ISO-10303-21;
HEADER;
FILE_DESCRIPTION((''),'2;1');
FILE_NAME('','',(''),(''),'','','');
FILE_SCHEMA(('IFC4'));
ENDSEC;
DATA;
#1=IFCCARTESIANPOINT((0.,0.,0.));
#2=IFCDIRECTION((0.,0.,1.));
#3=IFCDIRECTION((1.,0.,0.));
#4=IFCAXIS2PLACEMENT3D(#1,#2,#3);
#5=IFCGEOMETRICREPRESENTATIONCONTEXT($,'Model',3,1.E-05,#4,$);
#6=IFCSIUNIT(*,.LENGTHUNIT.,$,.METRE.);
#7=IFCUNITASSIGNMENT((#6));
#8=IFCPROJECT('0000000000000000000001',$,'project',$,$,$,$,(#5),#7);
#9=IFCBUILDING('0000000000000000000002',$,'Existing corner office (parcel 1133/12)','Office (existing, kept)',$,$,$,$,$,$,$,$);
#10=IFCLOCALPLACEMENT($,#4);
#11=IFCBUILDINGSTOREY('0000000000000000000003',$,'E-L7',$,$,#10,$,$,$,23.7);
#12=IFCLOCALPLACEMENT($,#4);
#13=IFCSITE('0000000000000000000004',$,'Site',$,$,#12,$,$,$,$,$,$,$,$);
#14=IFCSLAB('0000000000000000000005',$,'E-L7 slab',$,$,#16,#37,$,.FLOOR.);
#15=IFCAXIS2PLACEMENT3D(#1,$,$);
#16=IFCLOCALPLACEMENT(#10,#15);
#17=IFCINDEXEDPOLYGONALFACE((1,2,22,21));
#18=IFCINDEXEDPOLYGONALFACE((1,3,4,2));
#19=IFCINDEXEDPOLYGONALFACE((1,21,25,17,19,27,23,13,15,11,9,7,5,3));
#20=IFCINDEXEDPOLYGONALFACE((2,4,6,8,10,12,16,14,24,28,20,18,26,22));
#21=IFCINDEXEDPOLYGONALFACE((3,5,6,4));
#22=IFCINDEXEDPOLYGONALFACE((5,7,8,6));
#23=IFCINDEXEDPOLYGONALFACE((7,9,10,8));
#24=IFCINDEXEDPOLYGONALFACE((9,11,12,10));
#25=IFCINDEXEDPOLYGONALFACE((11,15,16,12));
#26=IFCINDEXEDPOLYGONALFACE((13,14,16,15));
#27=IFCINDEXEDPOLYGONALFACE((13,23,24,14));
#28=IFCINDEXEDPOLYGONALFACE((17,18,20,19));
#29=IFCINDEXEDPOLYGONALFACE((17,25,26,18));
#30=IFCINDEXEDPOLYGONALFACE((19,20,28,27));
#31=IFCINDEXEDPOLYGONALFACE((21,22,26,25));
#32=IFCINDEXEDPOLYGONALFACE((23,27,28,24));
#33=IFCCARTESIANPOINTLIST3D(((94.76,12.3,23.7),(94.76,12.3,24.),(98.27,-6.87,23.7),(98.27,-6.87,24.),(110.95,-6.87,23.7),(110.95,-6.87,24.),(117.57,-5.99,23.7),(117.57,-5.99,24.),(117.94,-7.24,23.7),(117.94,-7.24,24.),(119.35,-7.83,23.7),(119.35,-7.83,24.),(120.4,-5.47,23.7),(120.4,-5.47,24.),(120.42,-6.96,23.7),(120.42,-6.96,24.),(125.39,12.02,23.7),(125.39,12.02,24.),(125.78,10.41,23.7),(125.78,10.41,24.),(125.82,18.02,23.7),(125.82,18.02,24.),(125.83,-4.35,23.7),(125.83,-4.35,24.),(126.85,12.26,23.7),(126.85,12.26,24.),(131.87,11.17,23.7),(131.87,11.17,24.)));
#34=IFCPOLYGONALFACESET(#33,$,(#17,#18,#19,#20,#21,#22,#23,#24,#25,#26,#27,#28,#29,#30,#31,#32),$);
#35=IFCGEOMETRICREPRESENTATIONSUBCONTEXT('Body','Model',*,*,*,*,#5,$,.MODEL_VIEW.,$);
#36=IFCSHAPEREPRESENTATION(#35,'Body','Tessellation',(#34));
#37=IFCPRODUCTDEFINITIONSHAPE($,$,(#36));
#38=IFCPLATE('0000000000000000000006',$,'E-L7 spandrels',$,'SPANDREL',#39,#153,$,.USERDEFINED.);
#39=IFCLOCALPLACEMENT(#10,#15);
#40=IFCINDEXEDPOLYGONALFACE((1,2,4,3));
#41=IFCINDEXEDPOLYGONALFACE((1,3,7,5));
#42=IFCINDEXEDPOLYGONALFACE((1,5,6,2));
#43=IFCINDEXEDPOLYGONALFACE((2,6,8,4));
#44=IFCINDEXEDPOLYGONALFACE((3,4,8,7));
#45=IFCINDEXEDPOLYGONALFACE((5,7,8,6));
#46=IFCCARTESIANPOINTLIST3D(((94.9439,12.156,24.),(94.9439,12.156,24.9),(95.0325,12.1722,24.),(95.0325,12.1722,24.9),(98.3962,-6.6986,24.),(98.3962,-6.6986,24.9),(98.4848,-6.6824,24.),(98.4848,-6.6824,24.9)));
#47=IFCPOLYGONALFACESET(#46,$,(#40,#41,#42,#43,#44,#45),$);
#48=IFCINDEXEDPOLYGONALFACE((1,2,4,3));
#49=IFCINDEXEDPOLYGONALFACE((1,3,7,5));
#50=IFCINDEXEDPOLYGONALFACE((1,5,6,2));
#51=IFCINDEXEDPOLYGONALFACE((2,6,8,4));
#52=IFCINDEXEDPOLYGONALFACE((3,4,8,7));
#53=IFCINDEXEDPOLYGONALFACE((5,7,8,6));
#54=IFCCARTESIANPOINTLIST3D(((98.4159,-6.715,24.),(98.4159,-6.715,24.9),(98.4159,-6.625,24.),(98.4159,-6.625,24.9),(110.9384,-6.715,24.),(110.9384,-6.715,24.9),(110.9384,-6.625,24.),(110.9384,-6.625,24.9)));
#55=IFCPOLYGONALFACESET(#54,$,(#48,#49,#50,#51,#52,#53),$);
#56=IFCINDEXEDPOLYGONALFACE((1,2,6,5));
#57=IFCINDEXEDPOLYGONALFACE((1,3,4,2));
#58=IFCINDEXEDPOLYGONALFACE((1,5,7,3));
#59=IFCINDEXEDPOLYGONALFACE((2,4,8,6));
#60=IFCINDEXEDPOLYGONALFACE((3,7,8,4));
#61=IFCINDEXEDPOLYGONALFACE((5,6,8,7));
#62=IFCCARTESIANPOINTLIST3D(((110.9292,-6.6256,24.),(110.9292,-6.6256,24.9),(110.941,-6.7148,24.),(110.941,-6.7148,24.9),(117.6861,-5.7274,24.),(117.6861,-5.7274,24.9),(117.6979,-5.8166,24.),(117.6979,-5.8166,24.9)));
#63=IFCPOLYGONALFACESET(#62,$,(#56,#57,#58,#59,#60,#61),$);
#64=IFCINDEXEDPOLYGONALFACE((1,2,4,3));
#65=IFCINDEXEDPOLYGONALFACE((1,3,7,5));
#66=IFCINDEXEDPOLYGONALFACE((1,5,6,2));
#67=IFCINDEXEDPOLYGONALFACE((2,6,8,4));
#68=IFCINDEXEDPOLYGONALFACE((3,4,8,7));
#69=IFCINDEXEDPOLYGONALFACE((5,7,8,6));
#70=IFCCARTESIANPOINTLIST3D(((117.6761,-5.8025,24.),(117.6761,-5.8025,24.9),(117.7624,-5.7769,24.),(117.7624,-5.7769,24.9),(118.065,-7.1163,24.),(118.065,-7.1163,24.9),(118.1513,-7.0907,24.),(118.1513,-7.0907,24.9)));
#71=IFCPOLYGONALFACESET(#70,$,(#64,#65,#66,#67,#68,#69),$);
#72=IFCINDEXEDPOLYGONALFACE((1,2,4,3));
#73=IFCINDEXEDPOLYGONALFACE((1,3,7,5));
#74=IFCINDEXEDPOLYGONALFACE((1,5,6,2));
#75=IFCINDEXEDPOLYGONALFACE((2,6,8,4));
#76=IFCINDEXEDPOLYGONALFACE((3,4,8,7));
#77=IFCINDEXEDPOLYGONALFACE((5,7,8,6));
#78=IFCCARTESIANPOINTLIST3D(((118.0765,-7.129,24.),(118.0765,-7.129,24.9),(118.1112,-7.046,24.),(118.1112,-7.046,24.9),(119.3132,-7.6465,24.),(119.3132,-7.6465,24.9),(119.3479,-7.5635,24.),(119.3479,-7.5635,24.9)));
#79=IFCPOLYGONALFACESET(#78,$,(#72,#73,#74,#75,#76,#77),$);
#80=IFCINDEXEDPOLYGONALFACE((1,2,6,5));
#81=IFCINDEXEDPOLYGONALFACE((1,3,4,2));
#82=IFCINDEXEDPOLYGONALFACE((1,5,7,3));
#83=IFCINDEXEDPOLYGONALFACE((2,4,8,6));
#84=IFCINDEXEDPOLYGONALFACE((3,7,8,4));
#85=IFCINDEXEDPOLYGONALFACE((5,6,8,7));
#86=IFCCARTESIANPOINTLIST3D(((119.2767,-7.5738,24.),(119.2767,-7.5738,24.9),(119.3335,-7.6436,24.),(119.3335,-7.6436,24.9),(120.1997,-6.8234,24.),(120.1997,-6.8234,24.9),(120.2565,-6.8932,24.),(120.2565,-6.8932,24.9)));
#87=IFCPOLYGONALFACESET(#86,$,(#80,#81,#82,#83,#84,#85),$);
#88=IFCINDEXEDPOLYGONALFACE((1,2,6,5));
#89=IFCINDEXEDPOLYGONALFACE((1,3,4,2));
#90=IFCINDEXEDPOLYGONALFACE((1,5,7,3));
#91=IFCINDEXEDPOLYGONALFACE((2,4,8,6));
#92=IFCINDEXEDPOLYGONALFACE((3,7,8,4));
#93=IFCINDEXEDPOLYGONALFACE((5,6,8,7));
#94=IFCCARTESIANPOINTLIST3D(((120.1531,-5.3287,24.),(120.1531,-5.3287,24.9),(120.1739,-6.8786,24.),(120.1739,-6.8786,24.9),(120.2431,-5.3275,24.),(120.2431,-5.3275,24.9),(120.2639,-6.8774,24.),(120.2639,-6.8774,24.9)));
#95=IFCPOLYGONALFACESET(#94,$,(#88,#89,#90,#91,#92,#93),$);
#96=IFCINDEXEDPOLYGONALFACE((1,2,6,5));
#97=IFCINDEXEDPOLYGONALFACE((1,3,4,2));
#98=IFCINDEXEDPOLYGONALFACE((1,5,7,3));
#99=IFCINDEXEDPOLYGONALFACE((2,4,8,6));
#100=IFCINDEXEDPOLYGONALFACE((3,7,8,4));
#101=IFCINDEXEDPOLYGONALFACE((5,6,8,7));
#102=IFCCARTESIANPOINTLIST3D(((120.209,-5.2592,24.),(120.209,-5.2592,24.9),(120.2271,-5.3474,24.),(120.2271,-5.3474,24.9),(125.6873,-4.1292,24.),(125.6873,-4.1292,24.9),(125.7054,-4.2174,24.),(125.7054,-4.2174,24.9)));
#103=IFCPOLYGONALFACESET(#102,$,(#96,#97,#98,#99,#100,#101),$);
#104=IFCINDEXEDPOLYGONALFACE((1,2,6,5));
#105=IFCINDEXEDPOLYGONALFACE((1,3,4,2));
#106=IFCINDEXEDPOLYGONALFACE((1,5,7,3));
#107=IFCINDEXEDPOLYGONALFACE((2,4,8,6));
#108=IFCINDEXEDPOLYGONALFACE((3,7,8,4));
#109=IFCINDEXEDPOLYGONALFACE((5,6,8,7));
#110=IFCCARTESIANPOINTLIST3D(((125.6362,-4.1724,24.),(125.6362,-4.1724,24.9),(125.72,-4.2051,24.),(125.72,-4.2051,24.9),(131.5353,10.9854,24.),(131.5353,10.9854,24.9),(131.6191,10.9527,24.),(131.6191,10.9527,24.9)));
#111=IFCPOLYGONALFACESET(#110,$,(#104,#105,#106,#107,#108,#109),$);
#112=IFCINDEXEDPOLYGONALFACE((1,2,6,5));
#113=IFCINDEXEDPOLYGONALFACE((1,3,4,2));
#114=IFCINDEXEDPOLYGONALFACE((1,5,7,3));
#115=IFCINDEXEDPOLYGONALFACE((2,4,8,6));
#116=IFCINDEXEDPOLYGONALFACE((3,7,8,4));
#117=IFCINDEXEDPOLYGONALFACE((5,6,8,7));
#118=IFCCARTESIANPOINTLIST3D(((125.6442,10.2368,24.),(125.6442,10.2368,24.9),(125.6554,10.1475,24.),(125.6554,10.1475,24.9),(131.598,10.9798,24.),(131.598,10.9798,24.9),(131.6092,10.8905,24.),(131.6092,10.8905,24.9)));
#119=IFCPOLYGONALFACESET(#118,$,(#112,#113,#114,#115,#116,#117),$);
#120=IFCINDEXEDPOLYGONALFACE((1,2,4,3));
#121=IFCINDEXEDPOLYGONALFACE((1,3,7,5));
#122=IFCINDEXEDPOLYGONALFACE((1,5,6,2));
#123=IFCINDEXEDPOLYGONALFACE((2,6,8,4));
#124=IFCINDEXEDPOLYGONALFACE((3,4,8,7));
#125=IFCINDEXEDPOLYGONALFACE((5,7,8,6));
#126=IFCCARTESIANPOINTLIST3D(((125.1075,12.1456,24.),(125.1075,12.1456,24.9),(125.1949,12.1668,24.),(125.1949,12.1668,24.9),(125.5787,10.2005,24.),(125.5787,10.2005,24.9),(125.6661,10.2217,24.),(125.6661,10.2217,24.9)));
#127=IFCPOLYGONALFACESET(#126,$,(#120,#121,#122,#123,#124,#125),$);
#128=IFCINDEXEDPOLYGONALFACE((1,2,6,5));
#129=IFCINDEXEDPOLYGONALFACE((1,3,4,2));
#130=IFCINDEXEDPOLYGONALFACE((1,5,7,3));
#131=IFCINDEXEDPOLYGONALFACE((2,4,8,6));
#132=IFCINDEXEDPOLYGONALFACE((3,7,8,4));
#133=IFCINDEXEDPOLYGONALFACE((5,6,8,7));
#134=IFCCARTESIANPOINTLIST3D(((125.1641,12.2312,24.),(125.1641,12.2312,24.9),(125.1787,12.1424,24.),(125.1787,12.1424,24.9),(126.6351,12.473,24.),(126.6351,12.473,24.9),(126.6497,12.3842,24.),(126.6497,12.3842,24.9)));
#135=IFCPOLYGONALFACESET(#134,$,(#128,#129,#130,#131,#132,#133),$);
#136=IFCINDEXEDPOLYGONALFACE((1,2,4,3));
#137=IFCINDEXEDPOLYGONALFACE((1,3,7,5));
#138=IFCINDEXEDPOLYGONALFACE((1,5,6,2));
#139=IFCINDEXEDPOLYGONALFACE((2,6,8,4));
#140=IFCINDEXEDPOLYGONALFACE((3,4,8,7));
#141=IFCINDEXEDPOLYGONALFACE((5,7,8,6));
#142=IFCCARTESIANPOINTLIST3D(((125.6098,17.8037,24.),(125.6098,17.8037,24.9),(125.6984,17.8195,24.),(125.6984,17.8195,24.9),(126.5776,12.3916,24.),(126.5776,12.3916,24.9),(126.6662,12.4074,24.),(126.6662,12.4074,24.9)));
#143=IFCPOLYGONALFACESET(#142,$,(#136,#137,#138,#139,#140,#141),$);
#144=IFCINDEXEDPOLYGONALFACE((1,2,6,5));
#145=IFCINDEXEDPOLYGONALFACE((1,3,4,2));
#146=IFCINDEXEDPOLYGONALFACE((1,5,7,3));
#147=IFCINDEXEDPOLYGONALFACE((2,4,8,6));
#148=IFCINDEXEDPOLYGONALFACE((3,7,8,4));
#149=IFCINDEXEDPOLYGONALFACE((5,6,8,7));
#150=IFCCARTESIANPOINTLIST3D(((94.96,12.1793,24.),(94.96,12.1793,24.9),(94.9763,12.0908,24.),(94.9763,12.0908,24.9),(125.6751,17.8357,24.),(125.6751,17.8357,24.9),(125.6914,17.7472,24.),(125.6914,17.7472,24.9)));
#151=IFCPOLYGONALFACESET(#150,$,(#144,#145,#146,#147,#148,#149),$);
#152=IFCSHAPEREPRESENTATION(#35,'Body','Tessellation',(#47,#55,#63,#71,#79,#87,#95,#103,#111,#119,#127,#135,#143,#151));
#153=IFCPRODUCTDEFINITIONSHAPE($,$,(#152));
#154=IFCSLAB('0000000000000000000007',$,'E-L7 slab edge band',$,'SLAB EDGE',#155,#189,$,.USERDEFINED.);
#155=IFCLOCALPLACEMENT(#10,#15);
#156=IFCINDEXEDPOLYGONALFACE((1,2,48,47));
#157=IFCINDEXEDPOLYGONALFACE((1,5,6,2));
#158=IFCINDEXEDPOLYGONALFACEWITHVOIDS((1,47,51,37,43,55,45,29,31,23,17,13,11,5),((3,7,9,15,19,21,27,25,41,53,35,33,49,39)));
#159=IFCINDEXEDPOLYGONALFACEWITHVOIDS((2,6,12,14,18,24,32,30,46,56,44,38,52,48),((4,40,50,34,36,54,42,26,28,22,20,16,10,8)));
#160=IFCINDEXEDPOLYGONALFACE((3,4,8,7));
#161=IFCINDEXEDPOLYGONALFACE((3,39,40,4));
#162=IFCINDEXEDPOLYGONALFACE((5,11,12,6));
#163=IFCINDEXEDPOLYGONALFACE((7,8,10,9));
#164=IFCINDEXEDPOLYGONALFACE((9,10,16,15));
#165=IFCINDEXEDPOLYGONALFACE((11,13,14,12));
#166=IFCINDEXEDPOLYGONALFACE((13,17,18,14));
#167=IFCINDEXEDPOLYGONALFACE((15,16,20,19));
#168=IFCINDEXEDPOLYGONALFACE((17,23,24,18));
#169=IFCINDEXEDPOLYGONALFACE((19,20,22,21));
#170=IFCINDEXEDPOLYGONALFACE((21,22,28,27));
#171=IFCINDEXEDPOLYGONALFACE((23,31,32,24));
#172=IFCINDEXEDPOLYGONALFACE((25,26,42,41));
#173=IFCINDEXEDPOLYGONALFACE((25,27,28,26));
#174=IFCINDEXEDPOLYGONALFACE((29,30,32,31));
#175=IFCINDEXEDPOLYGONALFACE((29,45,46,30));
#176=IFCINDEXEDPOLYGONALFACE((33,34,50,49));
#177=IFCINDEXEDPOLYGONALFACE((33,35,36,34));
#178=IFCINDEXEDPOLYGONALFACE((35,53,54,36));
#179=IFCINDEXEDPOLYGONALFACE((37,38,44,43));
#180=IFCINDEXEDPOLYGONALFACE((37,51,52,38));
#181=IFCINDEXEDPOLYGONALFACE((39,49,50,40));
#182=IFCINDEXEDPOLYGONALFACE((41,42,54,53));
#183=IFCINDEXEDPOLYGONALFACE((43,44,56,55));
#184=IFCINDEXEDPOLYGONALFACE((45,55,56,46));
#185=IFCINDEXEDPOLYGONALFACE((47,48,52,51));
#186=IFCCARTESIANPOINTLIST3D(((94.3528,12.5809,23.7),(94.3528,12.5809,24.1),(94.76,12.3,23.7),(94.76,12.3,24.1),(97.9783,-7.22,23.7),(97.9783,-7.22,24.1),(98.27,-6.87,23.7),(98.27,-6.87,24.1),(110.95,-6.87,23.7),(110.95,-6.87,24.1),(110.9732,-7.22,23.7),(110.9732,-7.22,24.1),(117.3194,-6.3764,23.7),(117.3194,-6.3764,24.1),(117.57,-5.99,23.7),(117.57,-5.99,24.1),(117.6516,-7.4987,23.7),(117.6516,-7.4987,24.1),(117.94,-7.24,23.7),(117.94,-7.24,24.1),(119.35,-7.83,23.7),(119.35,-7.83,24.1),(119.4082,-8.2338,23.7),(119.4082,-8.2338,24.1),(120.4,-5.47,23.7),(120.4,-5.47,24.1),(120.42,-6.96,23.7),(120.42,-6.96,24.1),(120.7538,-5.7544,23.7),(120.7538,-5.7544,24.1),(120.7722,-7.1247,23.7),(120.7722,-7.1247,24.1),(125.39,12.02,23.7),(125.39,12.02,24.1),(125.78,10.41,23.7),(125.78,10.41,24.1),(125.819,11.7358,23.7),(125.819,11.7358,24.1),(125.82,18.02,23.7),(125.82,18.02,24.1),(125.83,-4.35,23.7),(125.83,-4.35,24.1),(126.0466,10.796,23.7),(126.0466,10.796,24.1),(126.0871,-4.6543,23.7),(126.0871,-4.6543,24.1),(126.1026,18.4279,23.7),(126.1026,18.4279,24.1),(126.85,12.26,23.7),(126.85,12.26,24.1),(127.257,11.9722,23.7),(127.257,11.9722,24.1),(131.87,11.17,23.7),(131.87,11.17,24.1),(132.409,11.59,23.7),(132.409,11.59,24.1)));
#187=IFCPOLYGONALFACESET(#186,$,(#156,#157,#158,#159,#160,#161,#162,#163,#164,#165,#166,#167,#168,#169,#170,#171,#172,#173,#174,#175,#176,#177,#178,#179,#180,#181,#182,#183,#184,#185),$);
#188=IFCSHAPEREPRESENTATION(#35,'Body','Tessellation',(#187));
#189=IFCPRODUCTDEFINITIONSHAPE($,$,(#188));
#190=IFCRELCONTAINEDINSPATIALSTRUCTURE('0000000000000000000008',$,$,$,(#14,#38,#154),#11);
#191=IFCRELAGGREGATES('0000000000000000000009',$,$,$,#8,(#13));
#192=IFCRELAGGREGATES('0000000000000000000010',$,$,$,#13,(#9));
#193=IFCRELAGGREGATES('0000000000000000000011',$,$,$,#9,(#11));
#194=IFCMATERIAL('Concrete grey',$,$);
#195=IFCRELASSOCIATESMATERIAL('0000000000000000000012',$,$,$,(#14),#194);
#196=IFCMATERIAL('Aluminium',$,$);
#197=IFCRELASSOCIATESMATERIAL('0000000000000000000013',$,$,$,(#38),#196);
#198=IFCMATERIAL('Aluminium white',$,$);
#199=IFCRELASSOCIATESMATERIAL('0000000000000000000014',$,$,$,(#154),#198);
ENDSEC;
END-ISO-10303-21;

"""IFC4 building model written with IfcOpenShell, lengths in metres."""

from ifc_helpers import new_model, si_unit, frame, origin_with_axes, place, context, subcontext, project, spatial, polyline, outline, extrude, material, element, save


model = new_model("IFC4")

# Units and contexts
model_context = context("Model", 3, precision=1e-05, world=origin_with_axes())
body_context = subcontext(model_context, "Body", "Model", "MODEL_VIEW")
ifc_project = project(units=[si_unit("LENGTHUNIT", "METRE")], contexts=[model_context])

# Site, building, storey
site_placement = place(None, origin_with_axes())
site = spatial("IfcSite", under=ifc_project, at=site_placement, Name="Site")
building = spatial("IfcBuilding", under=site, Name="Existing corner office (parcel 1133/12)", Description="Office (existing, kept)")
storey_placement = place(None, origin_with_axes())
storey = spatial("IfcBuildingStorey", under=building, at=storey_placement, Name="E-L7", Elevation=23.7)

# Shared definitions
ifc_material_1 = material(Name="Aluminium")

# Slab
ifc_material_2 = material(Name="Concrete grey")
slab_1_placement = place(storey_placement, origin_with_axes())
element("IfcSlab", 1, at=slab_1_placement, inside=storey, material=ifc_material_2, Name="E-L7 slab", PredefinedType="FLOOR", context=body_context, shape_type="SweptSolid", body=[
    extrude(outline(polyline([(94.76, 12.3), (98.27, -6.87), (110.95, -6.87), (117.57, -5.99), (117.94, -7.24), (119.35, -7.83), (120.42, -6.96), (120.4, -5.47), (125.83, -4.35), (131.87, 11.17), (125.78, 10.41), (125.39, 12.02), (126.85, 12.26), (125.82, 18.02), (94.76, 12.3)])), frame((0.0, 0.0, 23.7), z_axis=(0.0, 0.0, 1.0), x_axis=(1.0, 0.0, 0.0)), (0.0, 0.0, 1.0), 0.3),
])

# Plate
plate_placement = place(storey_placement, origin_with_axes())
element("IfcPlate", 2, at=plate_placement, inside=storey, material=ifc_material_1, Name="E-L7 spandrels", ObjectType="SPANDREL", PredefinedType="USERDEFINED", context=body_context, shape_type="SweptSolid", body=[
    extrude(outline(polyline([(94.9439, 12.156), (98.3962, -6.6986), (98.4848, -6.6824), (95.0325, 12.1722), (94.9439, 12.156)])), frame((0.0, 0.0, 24.0), z_axis=(0.0, 0.0, 1.0), x_axis=(1.0, 0.0, 0.0)), (0.0, 0.0, 1.0), 0.9),
    extrude(outline(polyline([(98.4159, -6.715), (110.9384, -6.715), (110.9384, -6.625), (98.4159, -6.625), (98.4159, -6.715)])), frame((0.0, 0.0, 24.0), z_axis=(0.0, 0.0, 1.0), x_axis=(1.0, 0.0, 0.0)), (0.0, 0.0, 1.0), 0.9),
    extrude(outline(polyline([(110.941, -6.7148), (117.6979, -5.8166), (117.6861, -5.7274), (110.9292, -6.6256), (110.941, -6.7148)])), frame((0.0, 0.0, 24.0), z_axis=(0.0, 0.0, 1.0), x_axis=(1.0, 0.0, 0.0)), (0.0, 0.0, 1.0), 0.9),
    extrude(outline(polyline([(117.6761, -5.8025), (118.065, -7.1163), (118.1513, -7.0907), (117.7624, -5.7769), (117.6761, -5.8025)])), frame((0.0, 0.0, 24.0), z_axis=(0.0, 0.0, 1.0), x_axis=(1.0, 0.0, 0.0)), (0.0, 0.0, 1.0), 0.9),
    extrude(outline(polyline([(118.0765, -7.129), (119.3132, -7.6465), (119.3479, -7.5635), (118.1112, -7.046), (118.0765, -7.129)])), frame((0.0, 0.0, 24.0), z_axis=(0.0, 0.0, 1.0), x_axis=(1.0, 0.0, 0.0)), (0.0, 0.0, 1.0), 0.9),
    extrude(outline(polyline([(119.3335, -7.6436), (120.2565, -6.8932), (120.1997, -6.8234), (119.2767, -7.5738), (119.3335, -7.6436)])), frame((0.0, 0.0, 24.0), z_axis=(0.0, 0.0, 1.0), x_axis=(1.0, 0.0, 0.0)), (0.0, 0.0, 1.0), 0.9),
    extrude(outline(polyline([(120.2639, -6.8774), (120.2431, -5.3275), (120.1531, -5.3287), (120.1739, -6.8786), (120.2639, -6.8774)])), frame((0.0, 0.0, 24.0), z_axis=(0.0, 0.0, 1.0), x_axis=(1.0, 0.0, 0.0)), (0.0, 0.0, 1.0), 0.9),
    extrude(outline(polyline([(120.2271, -5.3474), (125.7054, -4.2174), (125.6873, -4.1292), (120.209, -5.2592), (120.2271, -5.3474)])), frame((0.0, 0.0, 24.0), z_axis=(0.0, 0.0, 1.0), x_axis=(1.0, 0.0, 0.0)), (0.0, 0.0, 1.0), 0.9),
    extrude(outline(polyline([(125.72, -4.2051), (131.6191, 10.9527), (131.5353, 10.9854), (125.6362, -4.1724), (125.72, -4.2051)])), frame((0.0, 0.0, 24.0), z_axis=(0.0, 0.0, 1.0), x_axis=(1.0, 0.0, 0.0)), (0.0, 0.0, 1.0), 0.9),
    extrude(outline(polyline([(131.598, 10.9798), (125.6442, 10.2368), (125.6554, 10.1475), (131.6092, 10.8905), (131.598, 10.9798)])), frame((0.0, 0.0, 24.0), z_axis=(0.0, 0.0, 1.0), x_axis=(1.0, 0.0, 0.0)), (0.0, 0.0, 1.0), 0.9),
    extrude(outline(polyline([(125.6661, 10.2217), (125.1949, 12.1668), (125.1075, 12.1456), (125.5787, 10.2005), (125.6661, 10.2217)])), frame((0.0, 0.0, 24.0), z_axis=(0.0, 0.0, 1.0), x_axis=(1.0, 0.0, 0.0)), (0.0, 0.0, 1.0), 0.9),
    extrude(outline(polyline([(125.1787, 12.1424), (126.6497, 12.3842), (126.6351, 12.473), (125.1641, 12.2312), (125.1787, 12.1424)])), frame((0.0, 0.0, 24.0), z_axis=(0.0, 0.0, 1.0), x_axis=(1.0, 0.0, 0.0)), (0.0, 0.0, 1.0), 0.9),
    extrude(outline(polyline([(126.6662, 12.4074), (125.6984, 17.8195), (125.6098, 17.8037), (126.5776, 12.3916), (126.6662, 12.4074)])), frame((0.0, 0.0, 24.0), z_axis=(0.0, 0.0, 1.0), x_axis=(1.0, 0.0, 0.0)), (0.0, 0.0, 1.0), 0.9),
    extrude(outline(polyline([(125.6751, 17.8357), (94.96, 12.1793), (94.9763, 12.0908), (125.6914, 17.7472), (125.6751, 17.8357)])), frame((0.0, 0.0, 24.0), z_axis=(0.0, 0.0, 1.0), x_axis=(1.0, 0.0, 0.0)), (0.0, 0.0, 1.0), 0.9),
])

# Slab
ifc_material_3 = material(Name="Aluminium white")
slab_2_placement = place(storey_placement, origin_with_axes())
element("IfcSlab", 3, at=slab_2_placement, inside=storey, material=ifc_material_3, Name="E-L7 slab edge band", ObjectType="SLAB EDGE", PredefinedType="USERDEFINED", context=body_context, shape_type="SweptSolid", body=[
    extrude(outline(polyline([(94.3528, 12.5809), (97.9783, -7.22), (110.9732, -7.22), (117.3194, -6.3764), (117.6516, -7.4987), (119.4082, -8.2338), (120.7722, -7.1247), (120.7538, -5.7544), (126.0871, -4.6543), (132.409, 11.59), (126.0466, 10.796), (125.819, 11.7358), (127.257, 11.9722), (126.1026, 18.4279), (94.3528, 12.5809)]), holes=[polyline([(94.76, 12.3), (98.27, -6.87), (110.95, -6.87), (117.57, -5.99), (117.94, -7.24), (119.35, -7.83), (120.42, -6.96), (120.4, -5.47), (125.83, -4.35), (131.87, 11.17), (125.78, 10.41), (125.39, 12.02), (126.85, 12.26), (125.82, 18.02), (94.76, 12.3)])]), frame((0.0, 0.0, 23.7), z_axis=(0.0, 0.0, 1.0), x_axis=(1.0, 0.0, 0.0)), (0.0, 0.0, 1.0), 0.4),
])

save(model, "model.ifc")
